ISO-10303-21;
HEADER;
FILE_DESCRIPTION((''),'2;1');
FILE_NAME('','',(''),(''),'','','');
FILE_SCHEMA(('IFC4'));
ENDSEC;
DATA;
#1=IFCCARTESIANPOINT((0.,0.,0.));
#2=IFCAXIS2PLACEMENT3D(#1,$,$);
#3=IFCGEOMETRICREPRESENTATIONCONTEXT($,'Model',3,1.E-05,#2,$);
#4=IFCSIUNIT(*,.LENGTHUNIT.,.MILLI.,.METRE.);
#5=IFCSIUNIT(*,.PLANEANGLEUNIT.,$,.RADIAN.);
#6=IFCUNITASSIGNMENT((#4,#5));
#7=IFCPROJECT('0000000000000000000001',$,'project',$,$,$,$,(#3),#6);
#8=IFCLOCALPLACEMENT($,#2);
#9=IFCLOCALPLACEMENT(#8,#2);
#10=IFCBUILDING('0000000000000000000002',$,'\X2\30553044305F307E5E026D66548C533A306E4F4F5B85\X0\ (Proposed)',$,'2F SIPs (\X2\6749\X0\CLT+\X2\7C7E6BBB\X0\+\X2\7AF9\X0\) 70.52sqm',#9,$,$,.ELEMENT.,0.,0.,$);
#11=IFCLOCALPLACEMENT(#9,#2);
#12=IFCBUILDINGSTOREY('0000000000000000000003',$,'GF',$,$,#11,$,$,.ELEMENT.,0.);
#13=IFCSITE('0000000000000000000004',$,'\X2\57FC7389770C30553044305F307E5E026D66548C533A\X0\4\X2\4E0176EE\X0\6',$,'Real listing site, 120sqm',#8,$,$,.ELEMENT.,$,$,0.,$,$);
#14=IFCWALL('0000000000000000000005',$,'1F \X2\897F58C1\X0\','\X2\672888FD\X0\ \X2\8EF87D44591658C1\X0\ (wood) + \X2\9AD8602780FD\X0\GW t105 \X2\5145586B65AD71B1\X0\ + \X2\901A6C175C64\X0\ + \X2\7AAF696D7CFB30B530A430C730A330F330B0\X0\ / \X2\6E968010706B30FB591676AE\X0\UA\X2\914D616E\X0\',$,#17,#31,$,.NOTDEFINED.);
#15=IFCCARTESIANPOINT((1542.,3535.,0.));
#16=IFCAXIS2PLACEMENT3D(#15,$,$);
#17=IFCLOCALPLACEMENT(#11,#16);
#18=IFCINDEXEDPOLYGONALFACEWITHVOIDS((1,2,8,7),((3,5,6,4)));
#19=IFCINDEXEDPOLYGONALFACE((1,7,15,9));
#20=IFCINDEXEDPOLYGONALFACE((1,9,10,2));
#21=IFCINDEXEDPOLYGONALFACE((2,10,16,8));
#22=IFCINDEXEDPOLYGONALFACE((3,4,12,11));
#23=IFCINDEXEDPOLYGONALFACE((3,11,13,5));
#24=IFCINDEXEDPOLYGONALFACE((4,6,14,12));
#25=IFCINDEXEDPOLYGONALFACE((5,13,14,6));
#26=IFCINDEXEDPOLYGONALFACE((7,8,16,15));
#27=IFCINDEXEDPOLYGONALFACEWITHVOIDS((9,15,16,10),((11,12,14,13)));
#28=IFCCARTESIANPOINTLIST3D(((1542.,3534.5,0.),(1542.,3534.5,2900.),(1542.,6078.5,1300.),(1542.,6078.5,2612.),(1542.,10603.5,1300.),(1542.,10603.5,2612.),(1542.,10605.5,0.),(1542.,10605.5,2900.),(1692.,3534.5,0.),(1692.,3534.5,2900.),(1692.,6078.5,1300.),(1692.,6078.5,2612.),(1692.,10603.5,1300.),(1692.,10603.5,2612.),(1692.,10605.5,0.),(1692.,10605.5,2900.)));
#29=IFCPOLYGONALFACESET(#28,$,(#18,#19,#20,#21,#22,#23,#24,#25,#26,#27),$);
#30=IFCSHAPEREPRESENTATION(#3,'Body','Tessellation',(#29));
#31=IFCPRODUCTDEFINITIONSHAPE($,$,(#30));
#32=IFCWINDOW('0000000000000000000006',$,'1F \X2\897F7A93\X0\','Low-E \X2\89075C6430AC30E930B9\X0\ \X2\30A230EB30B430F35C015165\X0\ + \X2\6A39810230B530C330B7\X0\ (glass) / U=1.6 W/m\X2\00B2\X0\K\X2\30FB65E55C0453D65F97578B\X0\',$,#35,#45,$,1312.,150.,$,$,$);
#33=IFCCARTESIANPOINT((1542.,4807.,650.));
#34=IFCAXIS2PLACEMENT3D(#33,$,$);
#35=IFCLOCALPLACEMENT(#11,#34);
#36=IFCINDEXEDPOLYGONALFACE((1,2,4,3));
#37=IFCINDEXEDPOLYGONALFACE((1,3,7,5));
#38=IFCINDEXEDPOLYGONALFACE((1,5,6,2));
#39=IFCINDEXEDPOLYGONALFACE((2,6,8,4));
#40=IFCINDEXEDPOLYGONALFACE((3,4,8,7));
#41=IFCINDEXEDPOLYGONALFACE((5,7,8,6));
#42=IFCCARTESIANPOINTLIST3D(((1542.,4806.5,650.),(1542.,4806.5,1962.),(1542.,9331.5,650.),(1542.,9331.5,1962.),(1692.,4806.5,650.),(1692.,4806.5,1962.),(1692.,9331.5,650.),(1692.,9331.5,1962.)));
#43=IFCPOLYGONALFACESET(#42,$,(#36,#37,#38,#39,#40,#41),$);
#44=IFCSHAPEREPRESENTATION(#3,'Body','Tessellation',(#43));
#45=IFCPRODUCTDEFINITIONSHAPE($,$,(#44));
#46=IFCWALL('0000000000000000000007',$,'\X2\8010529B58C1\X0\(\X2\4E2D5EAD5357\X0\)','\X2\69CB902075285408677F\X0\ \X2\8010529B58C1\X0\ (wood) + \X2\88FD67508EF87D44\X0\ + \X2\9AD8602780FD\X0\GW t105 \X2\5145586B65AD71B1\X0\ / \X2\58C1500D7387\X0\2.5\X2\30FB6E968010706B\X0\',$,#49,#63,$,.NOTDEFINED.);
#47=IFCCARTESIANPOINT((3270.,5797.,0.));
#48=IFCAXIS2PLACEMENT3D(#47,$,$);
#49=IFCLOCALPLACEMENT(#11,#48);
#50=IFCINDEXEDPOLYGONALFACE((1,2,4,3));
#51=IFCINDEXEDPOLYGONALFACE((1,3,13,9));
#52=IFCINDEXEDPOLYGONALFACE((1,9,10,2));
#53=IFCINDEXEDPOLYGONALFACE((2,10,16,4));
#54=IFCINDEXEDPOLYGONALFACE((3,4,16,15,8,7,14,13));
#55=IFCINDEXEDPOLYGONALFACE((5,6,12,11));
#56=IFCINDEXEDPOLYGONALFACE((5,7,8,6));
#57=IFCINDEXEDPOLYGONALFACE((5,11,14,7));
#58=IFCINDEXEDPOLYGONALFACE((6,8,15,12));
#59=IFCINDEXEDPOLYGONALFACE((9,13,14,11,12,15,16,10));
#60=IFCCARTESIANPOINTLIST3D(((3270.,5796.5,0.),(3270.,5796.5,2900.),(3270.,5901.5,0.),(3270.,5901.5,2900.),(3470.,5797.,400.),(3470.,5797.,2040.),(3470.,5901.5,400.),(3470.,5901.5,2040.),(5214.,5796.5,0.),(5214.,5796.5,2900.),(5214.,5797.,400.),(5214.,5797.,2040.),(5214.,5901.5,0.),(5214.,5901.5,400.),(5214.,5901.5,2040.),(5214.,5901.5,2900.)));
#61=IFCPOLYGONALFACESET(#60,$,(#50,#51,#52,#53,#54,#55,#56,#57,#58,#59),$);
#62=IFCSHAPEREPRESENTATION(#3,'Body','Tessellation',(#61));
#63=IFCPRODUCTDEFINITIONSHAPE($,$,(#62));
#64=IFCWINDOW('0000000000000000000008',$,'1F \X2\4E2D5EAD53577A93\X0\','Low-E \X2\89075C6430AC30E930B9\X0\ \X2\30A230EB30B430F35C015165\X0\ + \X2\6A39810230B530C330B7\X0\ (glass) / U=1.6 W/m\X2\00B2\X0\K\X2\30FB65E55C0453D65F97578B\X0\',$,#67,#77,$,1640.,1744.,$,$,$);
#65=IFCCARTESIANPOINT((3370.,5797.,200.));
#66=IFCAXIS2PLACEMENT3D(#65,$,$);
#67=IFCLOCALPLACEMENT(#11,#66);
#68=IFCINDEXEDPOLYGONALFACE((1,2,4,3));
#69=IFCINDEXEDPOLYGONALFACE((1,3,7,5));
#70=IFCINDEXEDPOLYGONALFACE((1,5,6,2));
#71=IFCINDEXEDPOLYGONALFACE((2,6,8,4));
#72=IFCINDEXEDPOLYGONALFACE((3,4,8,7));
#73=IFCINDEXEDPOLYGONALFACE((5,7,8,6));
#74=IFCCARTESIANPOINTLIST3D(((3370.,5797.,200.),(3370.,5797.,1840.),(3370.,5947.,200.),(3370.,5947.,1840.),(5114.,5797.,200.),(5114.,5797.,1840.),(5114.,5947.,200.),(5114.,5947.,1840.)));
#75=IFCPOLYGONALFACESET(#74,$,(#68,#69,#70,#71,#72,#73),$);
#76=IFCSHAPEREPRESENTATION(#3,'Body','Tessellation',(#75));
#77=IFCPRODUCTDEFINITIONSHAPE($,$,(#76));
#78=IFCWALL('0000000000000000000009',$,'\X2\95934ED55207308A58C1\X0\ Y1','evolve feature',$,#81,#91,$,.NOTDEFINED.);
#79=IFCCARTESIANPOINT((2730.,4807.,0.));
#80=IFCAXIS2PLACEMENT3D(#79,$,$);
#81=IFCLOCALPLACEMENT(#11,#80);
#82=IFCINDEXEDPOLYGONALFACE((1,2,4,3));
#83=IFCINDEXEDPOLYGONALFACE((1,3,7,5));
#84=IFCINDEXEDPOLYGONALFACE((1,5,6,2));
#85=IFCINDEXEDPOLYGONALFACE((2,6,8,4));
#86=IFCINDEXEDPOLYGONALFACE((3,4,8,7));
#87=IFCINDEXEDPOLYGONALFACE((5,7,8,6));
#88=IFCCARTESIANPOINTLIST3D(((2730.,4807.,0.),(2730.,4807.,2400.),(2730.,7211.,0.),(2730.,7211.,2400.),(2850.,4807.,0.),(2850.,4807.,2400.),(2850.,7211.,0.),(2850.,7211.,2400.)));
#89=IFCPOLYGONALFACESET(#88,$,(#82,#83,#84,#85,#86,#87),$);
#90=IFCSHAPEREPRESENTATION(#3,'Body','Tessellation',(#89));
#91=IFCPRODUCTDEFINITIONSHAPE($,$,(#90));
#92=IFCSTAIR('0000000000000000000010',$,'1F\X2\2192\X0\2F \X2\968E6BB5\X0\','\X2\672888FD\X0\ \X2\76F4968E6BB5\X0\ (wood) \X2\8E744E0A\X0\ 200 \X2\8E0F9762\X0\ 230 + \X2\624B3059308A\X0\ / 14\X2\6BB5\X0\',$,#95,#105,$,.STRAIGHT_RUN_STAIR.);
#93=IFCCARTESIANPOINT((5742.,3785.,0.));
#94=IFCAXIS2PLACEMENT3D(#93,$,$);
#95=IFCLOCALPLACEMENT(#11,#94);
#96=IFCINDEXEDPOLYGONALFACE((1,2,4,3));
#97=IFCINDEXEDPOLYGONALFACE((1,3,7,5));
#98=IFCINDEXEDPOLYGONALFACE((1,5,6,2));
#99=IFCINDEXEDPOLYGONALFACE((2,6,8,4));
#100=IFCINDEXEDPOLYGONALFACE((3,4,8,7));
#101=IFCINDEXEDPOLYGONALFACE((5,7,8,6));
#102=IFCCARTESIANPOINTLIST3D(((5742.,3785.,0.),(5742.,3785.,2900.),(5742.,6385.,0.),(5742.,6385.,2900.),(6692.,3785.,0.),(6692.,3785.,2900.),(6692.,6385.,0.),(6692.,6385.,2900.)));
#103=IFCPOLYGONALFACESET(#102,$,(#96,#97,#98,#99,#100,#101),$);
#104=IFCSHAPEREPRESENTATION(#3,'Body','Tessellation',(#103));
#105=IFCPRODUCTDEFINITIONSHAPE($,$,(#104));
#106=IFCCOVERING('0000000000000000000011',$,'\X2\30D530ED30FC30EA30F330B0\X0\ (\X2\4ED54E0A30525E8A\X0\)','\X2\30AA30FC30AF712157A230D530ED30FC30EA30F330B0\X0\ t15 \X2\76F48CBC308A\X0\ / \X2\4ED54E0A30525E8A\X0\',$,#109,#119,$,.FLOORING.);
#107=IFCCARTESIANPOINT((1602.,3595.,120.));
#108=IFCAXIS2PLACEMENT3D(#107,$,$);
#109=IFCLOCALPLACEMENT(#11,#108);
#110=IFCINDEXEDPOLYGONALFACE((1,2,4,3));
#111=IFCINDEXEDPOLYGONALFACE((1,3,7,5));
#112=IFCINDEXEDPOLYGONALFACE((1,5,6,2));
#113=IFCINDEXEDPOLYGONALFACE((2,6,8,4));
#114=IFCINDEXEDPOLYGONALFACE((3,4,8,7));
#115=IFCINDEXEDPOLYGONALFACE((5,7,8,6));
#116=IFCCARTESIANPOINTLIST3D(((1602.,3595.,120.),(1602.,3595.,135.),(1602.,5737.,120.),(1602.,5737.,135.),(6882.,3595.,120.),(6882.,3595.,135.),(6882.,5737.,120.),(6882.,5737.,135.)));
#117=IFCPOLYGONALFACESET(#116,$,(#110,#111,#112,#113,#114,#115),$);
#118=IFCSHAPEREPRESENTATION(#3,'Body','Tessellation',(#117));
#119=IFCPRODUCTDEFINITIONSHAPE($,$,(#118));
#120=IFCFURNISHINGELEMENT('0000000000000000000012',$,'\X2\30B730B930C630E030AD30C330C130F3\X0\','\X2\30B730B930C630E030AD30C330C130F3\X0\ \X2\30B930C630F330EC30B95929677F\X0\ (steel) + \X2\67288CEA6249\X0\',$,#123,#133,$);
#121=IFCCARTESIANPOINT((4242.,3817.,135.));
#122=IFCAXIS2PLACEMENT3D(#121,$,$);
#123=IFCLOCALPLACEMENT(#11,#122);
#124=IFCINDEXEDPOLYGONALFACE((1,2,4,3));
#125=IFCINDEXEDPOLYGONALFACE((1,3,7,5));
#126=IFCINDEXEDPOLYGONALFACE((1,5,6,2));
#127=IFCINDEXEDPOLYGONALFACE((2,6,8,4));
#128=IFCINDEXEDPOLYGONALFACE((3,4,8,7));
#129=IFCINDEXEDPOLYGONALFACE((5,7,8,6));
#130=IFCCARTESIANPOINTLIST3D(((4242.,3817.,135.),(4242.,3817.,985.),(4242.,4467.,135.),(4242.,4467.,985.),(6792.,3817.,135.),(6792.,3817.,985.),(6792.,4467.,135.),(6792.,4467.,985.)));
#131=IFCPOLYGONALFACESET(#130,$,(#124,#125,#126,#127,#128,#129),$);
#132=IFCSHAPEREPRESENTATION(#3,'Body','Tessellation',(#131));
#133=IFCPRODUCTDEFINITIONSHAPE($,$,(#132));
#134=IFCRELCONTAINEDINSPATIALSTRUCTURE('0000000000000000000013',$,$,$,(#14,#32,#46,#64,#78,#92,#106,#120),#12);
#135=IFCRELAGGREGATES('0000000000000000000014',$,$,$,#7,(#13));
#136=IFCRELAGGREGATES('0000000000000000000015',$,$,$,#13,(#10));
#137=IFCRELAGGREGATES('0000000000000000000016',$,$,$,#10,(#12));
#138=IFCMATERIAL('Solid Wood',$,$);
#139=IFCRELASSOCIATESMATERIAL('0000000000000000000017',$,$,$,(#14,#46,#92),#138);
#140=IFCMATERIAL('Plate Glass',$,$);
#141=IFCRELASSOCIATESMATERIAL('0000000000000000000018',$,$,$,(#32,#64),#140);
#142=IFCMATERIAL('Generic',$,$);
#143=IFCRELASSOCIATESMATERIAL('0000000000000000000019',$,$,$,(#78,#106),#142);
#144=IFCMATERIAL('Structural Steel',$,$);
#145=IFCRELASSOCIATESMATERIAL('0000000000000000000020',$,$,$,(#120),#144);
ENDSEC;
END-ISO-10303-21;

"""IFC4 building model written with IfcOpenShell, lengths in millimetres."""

from ifc_helpers import new_model, si_unit, frame, frame_2d, origin, place, context, project, spatial, rectangle, extrude, material, element, fill, save


model = new_model("IFC4")

# Units and contexts
model_context = context("Model", 3, precision=1e-05, world=origin())
ifc_project = project(units=[si_unit("LENGTHUNIT", "METRE", prefix="MILLI"), si_unit("PLANEANGLEUNIT", "RADIAN")], contexts=[model_context])

# Site, building, storey
site_placement = place(None, origin())
site = spatial("IfcSite", under=ifc_project, at=site_placement, Name="埼玉県さいたま市浦和区4丁目6", ObjectType="Real listing site, 120sqm", CompositionType="ELEMENT", RefElevation=0.0)
building_placement = place(site_placement, origin())
building = spatial("IfcBuilding", under=site, at=building_placement, Name="さいたま市浦和区の住宅 (Proposed)", ObjectType="2F SIPs (杉CLT+籾殻+竹) 70.52sqm", CompositionType="ELEMENT", ElevationOfRefHeight=0.0, ElevationOfTerrain=0.0)
storey_placement = place(building_placement, origin())
storey = spatial("IfcBuildingStorey", under=building, at=storey_placement, Name="GF", CompositionType="ELEMENT", Elevation=0.0)

# Shared definitions
ifc_material_1 = material(Name="Solid Wood")

# Shared definitions
ifc_material_2 = material(Name="Plate Glass")

# Shared definitions
ifc_material_3 = material(Name="Generic")

# Walls, openings, windows
wall_1_placement = place(storey_placement, frame((1542.0, 3535.0, 0.0)))
wall_1 = element("IfcWall", 1, at=wall_1_placement, inside=storey, material=ifc_material_1, Name="1F 西壁", Description="木製 軸組外壁 (wood) + 高性能GW t105 充填断熱 + 通気層 + 窯業系サイディング / 準耐火・外皮UA配慮", PredefinedType="NOTDEFINED", context=model_context, shape_type="SweptSolid", body=[
    extrude(rectangle(XDim=150.0, YDim=7071.0, at=frame_2d((75.0, 3535.0))), frame((1542.0, 3535.0, 0.0)), (0.0, 0.0, 1.0), 2900.0),
])
opening_1_placement = place(storey_placement, frame((1542.0, 4807.0, 650.0)))
opening_1 = element("IfcOpeningElement", 2, at=opening_1_placement, cuts=wall_1, PredefinedType="NOTDEFINED", context=model_context, shape_type="SweptSolid", body=[
    extrude(rectangle(XDim=150.0, YDim=4525.0, at=frame_2d((75.0, 2262.0))), frame((1542.0, 4807.0, 650.0)), (0.0, 0.0, 1.0), 1312.0),
])
window_1_placement = place(storey_placement, frame((1542.0, 4807.0, 650.0)))
window_1 = element("IfcWindow", 3, at=window_1_placement, inside=storey, material=ifc_material_2, Name="1F 西窓", Description="Low-E 複層ガラス アルゴン封入 + 樹脂サッシ (glass) / U=1.6 W/m²K・日射取得型", OverallHeight=1312.0, OverallWidth=150.0, context=model_context, shape_type="SweptSolid", body=[
    extrude(rectangle(XDim=150.0, YDim=4525.0, at=frame_2d((75.0, 2262.0))), frame((1542.0, 4807.0, 650.0)), (0.0, 0.0, 1.0), 1312.0),
])
fill(opening_1, window_1)
wall_2_placement = place(storey_placement, frame((3270.0, 5797.0, 0.0)))
wall_2 = element("IfcWall", 4, at=wall_2_placement, inside=storey, material=ifc_material_1, Name="耐力壁(中庭南)", Description="構造用合板 耐力壁 (wood) + 製材軸組 + 高性能GW t105 充填断熱 / 壁倍率2.5・準耐火", PredefinedType="NOTDEFINED", context=model_context, shape_type="SweptSolid", body=[
    extrude(rectangle(XDim=1944.0, YDim=105.0, at=frame_2d((972.0, 52.0))), frame((3270.0, 5797.0, 0.0)), (0.0, 0.0, 1.0), 2900.0),
])
opening_2_placement = place(storey_placement, frame((3370.0, 5797.0, 200.0)))
opening_2 = element("IfcOpeningElement", 5, at=opening_2_placement, cuts=wall_2, PredefinedType="NOTDEFINED", context=model_context, shape_type="SweptSolid", body=[
    extrude(rectangle(XDim=1744.0, YDim=150.0, at=frame_2d((872.0, 75.0))), frame((3370.0, 5797.0, 200.0)), (0.0, 0.0, 1.0), 1640.0),
])
window_2_placement = place(storey_placement, frame((3370.0, 5797.0, 200.0)))
window_2 = element("IfcWindow", 6, at=window_2_placement, inside=storey, material=ifc_material_2, Name="1F 中庭南窓", Description="Low-E 複層ガラス アルゴン封入 + 樹脂サッシ (glass) / U=1.6 W/m²K・日射取得型", OverallHeight=1640.0, OverallWidth=1744.0, context=model_context, shape_type="SweptSolid", body=[
    extrude(rectangle(XDim=1744.0, YDim=150.0, at=frame_2d((872.0, 75.0))), frame((3370.0, 5797.0, 200.0)), (0.0, 0.0, 1.0), 1640.0),
])
fill(opening_2, window_2)

# Wall
wall_3_placement = place(storey_placement, frame((2730.0, 4807.0, 0.0)))
element("IfcWall", 7, at=wall_3_placement, inside=storey, material=ifc_material_3, Name="間仕切り壁 Y1", Description="evolve feature", PredefinedType="NOTDEFINED", context=model_context, shape_type="SweptSolid", body=[
    extrude(rectangle(XDim=120.0, YDim=2404.0, at=frame_2d((60.0, 1202.0))), frame((2730.0, 4807.0, 0.0)), (0.0, 0.0, 1.0), 2400.0),
])

# Stair
stair_placement = place(storey_placement, frame((5742.0, 3785.0, 0.0)))
element("IfcStair", 8, at=stair_placement, inside=storey, material=ifc_material_1, Name="1F→2F 階段", Description="木製 直階段 (wood) 蹴上 200 踏面 230 + 手すり / 14段", PredefinedType="STRAIGHT_RUN_STAIR", context=model_context, shape_type="SweptSolid", body=[
    extrude(rectangle(XDim=950.0, YDim=2600.0, at=frame_2d((475.0, 1300.0))), frame((5742.0, 3785.0, 0.0)), (0.0, 0.0, 1.0), 2900.0),
])

# Covering
covering_placement = place(storey_placement, frame((1602.0, 3595.0, 120.0)))
element("IfcCovering", 9, at=covering_placement, inside=storey, material=ifc_material_3, Name="フローリング (仕上げ床)", Description="オーク無垢フローリング t15 直貼り / 仕上げ床", PredefinedType="FLOORING", context=model_context, shape_type="SweptSolid", body=[
    extrude(rectangle(XDim=5280.0, YDim=2142.0, at=frame_2d((2640.0, 1071.0))), frame((1602.0, 3595.0, 120.0)), (0.0, 0.0, 1.0), 15.0),
])

# Furnishing element
ifc_material_4 = material(Name="Structural Steel")
furnishing_placement = place(storey_placement, frame((4242.0, 3817.0, 135.0)))
element("IfcFurnishingElement", 10, at=furnishing_placement, inside=storey, material=ifc_material_4, Name="システムキッチン", Description="システムキッチン ステンレス天板 (steel) + 木質扉", context=model_context, shape_type="SweptSolid", body=[
    extrude(rectangle(XDim=2550.0, YDim=650.0, at=frame_2d((1275.0, 325.0))), frame((4242.0, 3817.0, 135.0)), (0.0, 0.0, 1.0), 850.0),
])

save(model, "model.ifc")
